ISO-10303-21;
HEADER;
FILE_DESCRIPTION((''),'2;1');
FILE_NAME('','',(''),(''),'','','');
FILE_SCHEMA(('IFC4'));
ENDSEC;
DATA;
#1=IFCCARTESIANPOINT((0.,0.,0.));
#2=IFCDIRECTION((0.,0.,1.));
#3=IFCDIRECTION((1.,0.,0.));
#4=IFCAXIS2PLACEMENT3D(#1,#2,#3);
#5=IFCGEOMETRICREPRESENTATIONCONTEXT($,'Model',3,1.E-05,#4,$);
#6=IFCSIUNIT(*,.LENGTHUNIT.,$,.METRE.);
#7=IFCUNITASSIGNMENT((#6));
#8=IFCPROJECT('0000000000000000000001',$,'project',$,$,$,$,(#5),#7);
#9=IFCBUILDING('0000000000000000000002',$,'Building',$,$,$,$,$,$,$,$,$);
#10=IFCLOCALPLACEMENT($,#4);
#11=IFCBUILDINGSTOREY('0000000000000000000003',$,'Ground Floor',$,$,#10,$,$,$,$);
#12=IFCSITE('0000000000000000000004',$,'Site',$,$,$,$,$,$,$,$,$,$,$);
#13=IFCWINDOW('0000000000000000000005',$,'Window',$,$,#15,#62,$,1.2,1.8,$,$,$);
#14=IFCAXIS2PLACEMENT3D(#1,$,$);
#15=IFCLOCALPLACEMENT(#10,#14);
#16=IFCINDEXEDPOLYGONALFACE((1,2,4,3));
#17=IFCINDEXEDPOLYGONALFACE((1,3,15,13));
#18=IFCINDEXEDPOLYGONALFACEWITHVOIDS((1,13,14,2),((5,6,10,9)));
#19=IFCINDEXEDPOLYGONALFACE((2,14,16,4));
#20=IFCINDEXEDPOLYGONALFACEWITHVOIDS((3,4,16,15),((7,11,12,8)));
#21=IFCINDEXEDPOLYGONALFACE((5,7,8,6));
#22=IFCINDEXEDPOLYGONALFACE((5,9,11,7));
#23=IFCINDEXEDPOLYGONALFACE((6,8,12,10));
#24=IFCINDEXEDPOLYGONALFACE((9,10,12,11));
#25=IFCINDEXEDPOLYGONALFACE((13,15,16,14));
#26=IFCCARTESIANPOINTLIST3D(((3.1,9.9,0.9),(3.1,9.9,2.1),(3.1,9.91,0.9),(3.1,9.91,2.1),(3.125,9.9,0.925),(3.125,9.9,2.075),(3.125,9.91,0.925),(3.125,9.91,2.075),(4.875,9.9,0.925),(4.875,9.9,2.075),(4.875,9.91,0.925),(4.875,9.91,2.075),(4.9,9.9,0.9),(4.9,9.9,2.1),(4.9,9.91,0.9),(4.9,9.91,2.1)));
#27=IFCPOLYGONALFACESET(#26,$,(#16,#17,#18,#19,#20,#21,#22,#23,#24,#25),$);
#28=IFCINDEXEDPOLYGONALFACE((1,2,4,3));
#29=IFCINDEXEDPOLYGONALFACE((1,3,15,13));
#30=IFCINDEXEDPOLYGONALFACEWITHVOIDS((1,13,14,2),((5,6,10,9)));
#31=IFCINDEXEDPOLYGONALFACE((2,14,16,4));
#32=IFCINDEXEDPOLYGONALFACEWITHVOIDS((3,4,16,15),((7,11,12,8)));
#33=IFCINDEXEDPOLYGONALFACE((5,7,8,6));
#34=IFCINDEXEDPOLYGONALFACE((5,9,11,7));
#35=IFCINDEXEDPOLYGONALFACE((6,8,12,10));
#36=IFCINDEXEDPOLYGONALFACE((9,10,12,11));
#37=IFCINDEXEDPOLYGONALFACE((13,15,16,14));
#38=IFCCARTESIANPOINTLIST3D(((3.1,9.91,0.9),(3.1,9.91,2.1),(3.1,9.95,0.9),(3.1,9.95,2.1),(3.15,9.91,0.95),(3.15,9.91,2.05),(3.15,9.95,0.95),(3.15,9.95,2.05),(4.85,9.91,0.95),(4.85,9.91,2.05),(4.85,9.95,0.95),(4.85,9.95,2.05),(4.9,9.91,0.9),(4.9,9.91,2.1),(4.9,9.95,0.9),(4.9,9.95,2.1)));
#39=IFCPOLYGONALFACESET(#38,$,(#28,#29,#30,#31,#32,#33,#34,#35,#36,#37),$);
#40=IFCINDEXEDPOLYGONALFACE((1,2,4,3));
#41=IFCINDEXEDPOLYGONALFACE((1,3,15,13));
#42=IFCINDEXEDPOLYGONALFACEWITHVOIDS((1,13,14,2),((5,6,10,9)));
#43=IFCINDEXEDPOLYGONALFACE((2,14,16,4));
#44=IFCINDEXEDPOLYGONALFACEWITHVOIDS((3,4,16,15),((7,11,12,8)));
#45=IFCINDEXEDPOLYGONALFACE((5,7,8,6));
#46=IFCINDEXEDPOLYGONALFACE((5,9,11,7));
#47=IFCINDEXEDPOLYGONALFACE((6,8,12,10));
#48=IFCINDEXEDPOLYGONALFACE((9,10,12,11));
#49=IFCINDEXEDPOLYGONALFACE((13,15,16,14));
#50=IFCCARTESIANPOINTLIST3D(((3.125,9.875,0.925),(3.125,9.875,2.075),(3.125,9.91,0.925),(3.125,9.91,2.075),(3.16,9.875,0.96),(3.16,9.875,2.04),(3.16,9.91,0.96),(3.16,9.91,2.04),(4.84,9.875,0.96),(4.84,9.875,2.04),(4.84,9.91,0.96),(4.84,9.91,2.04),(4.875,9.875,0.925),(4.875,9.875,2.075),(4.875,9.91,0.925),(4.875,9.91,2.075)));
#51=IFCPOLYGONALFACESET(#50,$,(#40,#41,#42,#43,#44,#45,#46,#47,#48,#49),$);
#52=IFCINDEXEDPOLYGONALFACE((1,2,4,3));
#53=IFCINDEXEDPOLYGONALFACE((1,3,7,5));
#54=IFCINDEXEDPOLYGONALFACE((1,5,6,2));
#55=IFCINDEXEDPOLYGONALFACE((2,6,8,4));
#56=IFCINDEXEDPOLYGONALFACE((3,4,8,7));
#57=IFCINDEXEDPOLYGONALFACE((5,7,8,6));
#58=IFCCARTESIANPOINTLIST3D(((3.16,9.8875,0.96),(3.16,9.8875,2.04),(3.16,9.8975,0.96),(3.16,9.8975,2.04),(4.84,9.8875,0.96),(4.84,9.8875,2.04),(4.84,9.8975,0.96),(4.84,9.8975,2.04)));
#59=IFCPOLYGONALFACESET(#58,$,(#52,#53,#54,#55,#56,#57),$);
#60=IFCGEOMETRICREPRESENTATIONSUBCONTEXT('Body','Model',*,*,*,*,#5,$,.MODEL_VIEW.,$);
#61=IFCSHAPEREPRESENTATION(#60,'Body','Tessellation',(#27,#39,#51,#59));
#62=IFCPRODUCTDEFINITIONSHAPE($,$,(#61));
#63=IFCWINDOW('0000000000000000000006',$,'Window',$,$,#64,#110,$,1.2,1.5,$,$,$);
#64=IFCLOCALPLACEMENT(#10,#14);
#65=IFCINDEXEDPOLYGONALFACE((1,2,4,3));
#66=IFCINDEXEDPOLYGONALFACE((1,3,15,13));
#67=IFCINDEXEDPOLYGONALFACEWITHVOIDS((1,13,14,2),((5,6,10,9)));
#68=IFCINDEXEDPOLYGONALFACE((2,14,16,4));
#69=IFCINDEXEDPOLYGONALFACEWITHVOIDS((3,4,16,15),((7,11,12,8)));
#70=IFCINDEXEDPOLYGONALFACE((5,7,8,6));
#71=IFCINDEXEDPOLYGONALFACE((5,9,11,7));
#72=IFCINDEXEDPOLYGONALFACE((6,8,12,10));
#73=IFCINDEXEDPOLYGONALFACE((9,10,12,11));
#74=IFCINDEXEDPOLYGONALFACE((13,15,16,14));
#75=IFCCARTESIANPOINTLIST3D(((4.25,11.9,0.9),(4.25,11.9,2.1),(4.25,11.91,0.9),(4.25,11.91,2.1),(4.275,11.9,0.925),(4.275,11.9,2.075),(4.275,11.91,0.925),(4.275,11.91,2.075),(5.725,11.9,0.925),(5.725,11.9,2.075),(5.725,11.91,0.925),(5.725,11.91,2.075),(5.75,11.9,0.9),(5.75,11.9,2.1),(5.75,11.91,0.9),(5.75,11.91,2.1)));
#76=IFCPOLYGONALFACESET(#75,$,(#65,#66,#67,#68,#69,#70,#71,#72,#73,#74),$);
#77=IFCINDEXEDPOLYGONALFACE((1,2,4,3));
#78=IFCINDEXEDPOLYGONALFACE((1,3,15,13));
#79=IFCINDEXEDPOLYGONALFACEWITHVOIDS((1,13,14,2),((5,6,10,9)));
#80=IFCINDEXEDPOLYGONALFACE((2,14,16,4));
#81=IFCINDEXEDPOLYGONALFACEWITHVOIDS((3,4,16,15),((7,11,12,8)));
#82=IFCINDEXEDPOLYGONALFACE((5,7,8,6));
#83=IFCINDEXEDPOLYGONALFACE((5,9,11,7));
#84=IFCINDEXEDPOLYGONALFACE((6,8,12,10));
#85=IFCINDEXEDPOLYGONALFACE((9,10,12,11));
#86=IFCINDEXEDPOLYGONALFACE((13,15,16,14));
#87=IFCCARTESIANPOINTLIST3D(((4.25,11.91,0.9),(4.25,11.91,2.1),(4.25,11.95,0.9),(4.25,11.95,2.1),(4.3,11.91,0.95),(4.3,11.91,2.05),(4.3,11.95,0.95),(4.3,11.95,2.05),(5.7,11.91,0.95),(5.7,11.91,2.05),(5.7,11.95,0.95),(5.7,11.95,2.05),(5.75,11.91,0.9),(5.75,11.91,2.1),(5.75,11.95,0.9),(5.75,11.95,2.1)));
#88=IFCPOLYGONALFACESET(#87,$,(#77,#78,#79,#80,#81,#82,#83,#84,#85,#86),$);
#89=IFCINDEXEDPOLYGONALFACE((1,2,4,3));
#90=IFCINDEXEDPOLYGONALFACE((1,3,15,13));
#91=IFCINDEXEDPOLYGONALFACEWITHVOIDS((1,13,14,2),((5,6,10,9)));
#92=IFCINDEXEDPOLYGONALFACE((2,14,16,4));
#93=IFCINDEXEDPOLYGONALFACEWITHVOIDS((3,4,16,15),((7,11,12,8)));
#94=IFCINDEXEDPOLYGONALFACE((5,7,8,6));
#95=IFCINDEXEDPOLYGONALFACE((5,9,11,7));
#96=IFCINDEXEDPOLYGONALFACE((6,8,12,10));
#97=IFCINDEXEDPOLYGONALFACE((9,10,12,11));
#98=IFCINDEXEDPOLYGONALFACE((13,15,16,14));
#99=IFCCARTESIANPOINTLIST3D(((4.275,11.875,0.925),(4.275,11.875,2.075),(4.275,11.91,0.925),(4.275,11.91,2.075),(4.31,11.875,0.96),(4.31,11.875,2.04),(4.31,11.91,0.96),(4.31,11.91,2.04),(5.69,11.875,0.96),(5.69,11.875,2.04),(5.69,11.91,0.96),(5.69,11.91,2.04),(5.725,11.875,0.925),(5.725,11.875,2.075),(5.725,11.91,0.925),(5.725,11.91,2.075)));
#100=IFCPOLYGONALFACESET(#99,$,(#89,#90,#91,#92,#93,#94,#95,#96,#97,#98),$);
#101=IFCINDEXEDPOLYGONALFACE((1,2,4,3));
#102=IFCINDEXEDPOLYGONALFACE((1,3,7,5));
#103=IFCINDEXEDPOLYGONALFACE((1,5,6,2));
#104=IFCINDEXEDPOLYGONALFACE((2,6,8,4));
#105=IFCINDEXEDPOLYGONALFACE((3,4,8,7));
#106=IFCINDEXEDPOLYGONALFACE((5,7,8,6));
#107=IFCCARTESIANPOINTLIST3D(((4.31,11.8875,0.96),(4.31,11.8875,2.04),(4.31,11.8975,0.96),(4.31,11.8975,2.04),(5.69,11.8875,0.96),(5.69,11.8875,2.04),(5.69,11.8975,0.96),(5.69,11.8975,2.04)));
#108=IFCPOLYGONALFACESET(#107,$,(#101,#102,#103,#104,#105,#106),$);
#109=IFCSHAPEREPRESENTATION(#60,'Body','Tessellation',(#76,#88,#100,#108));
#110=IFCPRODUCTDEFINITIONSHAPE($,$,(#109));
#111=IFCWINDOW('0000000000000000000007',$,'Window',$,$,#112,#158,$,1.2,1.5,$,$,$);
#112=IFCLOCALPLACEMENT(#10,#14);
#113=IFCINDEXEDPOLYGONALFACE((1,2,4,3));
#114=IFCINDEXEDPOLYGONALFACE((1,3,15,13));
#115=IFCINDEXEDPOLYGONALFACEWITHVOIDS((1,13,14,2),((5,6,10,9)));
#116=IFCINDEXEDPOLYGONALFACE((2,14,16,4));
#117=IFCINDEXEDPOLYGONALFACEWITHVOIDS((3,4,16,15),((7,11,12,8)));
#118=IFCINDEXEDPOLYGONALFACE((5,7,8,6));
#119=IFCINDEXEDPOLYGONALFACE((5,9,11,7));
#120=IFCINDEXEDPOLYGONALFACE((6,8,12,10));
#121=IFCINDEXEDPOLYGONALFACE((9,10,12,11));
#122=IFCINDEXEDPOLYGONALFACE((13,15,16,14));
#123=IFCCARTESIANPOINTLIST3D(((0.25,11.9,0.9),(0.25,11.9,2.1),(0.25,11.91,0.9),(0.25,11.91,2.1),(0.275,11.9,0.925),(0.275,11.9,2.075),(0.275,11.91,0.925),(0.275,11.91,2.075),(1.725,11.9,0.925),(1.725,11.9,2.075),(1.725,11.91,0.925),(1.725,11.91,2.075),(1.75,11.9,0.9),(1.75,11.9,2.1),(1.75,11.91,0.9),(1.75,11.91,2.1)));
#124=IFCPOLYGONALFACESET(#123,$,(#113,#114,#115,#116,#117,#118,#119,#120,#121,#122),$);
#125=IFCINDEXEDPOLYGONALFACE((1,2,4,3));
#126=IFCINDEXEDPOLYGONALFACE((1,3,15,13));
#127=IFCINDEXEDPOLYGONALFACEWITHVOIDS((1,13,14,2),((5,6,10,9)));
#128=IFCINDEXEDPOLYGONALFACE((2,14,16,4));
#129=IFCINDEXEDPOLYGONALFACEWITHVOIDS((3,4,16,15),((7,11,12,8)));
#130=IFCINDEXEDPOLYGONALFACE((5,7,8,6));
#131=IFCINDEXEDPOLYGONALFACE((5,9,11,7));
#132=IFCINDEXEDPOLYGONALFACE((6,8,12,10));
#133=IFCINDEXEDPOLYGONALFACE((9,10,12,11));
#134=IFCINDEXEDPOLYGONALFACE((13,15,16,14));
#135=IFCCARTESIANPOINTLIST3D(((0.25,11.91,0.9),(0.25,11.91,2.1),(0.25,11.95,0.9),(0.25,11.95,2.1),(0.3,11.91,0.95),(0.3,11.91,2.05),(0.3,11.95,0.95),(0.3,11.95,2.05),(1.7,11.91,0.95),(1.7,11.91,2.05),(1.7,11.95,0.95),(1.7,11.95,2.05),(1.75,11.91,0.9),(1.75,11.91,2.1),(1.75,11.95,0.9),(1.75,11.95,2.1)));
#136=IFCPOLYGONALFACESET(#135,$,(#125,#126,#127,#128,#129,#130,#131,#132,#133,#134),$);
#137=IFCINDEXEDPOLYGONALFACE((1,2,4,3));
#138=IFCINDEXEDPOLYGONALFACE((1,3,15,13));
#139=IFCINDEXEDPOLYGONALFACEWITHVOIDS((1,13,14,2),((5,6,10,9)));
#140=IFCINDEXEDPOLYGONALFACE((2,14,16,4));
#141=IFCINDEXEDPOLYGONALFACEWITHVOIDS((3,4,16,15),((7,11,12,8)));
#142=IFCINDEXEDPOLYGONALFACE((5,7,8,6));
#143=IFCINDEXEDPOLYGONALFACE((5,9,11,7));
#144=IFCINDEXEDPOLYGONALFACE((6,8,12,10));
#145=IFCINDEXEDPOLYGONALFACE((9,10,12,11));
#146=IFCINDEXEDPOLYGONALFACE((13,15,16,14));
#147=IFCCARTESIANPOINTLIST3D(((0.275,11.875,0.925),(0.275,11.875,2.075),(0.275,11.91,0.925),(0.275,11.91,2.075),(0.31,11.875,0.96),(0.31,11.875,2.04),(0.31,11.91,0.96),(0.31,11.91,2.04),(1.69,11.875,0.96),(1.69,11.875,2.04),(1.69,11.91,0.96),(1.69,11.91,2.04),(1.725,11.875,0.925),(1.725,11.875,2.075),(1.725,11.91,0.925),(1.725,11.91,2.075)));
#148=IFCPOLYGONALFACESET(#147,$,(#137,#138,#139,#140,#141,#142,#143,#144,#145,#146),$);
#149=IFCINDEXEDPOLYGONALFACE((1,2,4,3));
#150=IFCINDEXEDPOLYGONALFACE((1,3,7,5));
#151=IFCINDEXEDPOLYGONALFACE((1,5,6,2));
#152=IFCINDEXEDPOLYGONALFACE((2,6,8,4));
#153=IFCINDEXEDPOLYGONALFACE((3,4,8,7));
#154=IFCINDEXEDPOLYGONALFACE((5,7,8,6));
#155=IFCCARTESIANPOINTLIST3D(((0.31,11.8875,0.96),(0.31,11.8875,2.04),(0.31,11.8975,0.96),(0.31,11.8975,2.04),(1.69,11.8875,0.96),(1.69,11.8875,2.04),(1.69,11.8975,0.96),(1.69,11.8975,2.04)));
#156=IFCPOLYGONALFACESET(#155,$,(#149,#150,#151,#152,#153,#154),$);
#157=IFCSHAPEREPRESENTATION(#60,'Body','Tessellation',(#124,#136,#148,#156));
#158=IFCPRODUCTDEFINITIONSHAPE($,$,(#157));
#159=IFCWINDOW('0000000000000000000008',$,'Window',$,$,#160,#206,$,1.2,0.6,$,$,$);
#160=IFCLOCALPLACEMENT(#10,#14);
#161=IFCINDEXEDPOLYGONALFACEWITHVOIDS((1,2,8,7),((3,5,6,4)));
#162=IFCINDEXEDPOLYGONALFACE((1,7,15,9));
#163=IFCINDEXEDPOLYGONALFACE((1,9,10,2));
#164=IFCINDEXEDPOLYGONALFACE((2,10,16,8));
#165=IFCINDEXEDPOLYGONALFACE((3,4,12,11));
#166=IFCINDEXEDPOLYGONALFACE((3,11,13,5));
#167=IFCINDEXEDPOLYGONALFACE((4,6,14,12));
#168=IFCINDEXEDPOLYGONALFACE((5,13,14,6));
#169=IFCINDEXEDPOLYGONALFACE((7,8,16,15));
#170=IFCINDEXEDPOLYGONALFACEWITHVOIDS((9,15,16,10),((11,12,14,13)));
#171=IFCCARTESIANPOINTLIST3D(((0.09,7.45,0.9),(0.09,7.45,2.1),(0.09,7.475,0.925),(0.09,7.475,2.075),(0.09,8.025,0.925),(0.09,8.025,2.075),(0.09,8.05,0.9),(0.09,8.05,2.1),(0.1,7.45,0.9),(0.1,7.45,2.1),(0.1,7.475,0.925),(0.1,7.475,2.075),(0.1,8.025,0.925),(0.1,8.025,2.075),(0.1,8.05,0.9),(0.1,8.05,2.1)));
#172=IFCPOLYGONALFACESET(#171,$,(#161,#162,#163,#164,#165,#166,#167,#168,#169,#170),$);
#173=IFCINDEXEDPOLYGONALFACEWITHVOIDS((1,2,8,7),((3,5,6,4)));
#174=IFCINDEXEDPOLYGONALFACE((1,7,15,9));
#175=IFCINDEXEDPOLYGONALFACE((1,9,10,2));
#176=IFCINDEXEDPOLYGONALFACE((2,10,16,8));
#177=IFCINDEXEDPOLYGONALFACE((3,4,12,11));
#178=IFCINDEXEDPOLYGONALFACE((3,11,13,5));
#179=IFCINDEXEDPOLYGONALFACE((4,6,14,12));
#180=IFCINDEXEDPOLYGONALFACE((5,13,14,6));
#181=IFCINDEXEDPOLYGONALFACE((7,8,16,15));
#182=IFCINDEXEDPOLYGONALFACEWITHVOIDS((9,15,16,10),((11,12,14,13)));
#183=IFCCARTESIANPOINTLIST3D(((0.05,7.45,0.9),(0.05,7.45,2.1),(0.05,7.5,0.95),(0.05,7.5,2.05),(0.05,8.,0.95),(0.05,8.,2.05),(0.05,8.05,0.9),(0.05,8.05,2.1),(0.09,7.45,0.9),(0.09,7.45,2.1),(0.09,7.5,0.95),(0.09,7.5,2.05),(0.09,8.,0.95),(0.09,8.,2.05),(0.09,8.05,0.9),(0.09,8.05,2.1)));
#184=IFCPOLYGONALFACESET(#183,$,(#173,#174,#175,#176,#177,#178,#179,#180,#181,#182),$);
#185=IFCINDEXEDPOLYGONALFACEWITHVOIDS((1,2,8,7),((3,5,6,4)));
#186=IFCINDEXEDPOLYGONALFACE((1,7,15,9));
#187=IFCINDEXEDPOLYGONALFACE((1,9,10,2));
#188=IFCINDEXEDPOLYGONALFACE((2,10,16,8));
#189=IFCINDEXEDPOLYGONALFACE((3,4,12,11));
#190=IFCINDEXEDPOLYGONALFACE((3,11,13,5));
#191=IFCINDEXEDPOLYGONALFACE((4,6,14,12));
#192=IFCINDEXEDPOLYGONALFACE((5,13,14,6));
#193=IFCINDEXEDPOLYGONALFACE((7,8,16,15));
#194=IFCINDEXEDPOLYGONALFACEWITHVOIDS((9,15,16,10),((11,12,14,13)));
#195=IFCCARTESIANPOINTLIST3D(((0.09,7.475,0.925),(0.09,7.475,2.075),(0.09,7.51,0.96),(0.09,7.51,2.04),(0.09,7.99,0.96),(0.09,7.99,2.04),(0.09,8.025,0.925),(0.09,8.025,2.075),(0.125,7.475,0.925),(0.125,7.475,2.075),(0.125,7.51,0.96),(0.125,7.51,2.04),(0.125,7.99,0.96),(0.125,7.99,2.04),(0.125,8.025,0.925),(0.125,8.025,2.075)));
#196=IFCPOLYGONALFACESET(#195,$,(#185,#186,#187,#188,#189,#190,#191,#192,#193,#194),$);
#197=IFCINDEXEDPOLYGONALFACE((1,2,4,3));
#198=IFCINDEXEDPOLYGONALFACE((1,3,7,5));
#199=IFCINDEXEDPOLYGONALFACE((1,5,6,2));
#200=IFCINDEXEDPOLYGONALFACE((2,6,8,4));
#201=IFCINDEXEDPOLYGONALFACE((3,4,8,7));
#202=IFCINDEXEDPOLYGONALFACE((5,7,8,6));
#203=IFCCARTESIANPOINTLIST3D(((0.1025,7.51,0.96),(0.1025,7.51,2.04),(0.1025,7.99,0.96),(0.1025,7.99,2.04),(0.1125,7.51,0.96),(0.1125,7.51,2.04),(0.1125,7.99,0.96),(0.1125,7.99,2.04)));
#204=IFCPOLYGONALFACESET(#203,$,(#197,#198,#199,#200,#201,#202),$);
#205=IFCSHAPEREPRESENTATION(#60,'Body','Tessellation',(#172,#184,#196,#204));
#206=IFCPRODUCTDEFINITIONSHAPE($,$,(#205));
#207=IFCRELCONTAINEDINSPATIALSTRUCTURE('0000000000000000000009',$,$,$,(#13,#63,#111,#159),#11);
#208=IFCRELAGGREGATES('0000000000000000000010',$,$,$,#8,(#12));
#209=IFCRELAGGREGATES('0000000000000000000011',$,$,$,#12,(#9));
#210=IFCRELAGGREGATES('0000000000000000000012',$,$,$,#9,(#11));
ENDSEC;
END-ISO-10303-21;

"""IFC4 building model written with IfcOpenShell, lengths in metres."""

from ifc_helpers import new_model, si_unit, frame, origin_with_axes, place, context, subcontext, project, spatial, line, indexed_curve, outline, extrude, element, save


model = new_model("IFC4")

# Units and contexts
model_context = context("Model", 3, precision=1e-05, world=origin_with_axes())
body_context = subcontext(model_context, "Body", "Model", "MODEL_VIEW")
ifc_project = project(units=[si_unit("LENGTHUNIT", "METRE")], contexts=[model_context])

# Site, building, storey
site = spatial("IfcSite", under=ifc_project, Name="Site")
building = spatial("IfcBuilding", under=site, Name="Building")
storey_placement = place(None, origin_with_axes())
storey = spatial("IfcBuildingStorey", under=building, at=storey_placement, Name="Ground Floor")

# Windows
window_1_placement = place(storey_placement, frame((4.9, 10.0, 0.9), z_axis=(0.0, 0.0, 1.0), x_axis=(-1.0, 0.0, 0.0)))
element("IfcWindow", 1, at=window_1_placement, inside=storey, Name="Window", OverallHeight=1.2, OverallWidth=1.8, context=body_context, shape_type="SweptSolid", body=[
    extrude(outline(indexed_curve([(0.0, 0.0), (1.8, 0.0), (1.8, 1.2), (0.0, 1.2)], segments=[line(1, 2, 3, 4, 1)]), holes=[indexed_curve([(0.025, 0.025), (1.775, 0.025), (1.775, 1.175), (0.025, 1.175)], segments=[line(1, 2, 3, 4, 1)])]), frame((0.0, 0.09, 0.0), z_axis=(0.0, -1.0, 0.0), x_axis=(1.0, 0.0, 0.0)), (0.0, 0.0, -1.0), 0.01),
    extrude(outline(indexed_curve([(0.0, 0.0), (1.8, 0.0), (1.8, 1.2), (0.0, 1.2)], segments=[line(1, 2, 3, 4, 1)]), holes=[indexed_curve([(0.05, 0.05), (1.75, 0.05), (1.75, 1.15), (0.05, 1.15)], segments=[line(1, 2, 3, 4, 1)])]), frame((0.0, 0.05, 0.0), z_axis=(0.0, -1.0, 0.0), x_axis=(1.0, 0.0, 0.0)), (0.0, 0.0, -1.0), 0.04),
    extrude(outline(indexed_curve([(0.0, 0.0), (1.75, 0.0), (1.75, 1.15), (0.0, 1.15)], segments=[line(1, 2, 3, 4, 1)]), holes=[indexed_curve([(0.035, 0.035), (1.715, 0.035), (1.715, 1.115), (0.035, 1.115)], segments=[line(1, 2, 3, 4, 1)])]), frame((0.025, 0.09, 0.025), z_axis=(0.0, -1.0, 0.0), x_axis=(1.0, 0.0, 0.0)), (0.0, 0.0, -1.0), 0.035),
    extrude(outline(indexed_curve([(0.035, 0.035), (1.715, 0.035), (1.715, 1.115), (0.035, 1.115)], segments=[line(1, 2, 3, 4, 1)])), frame((0.025, 0.1025, 0.025), z_axis=(0.0, -1.0, 0.0), x_axis=(1.0, 0.0, 0.0)), (0.0, 0.0, -1.0), 0.01),
])
for number, where, z_axis, x_axis, name in (
    (2, (5.75, 12.0, 0.9), (0.0, 0.0, 1.0), (-1.0, 0.0, 0.0), "Window"),
    (3, (1.75, 12.0, 0.9), (0.0, 0.0, 1.0), (-1.0, 0.0, 0.0), "Window"),
):
    element("IfcWindow", number, at=place(storey_placement, frame(where, z_axis=z_axis, x_axis=x_axis)), inside=storey, Name=name, OverallHeight=1.2, OverallWidth=1.5, context=body_context, shape_type="SweptSolid", body=[
        extrude(outline(indexed_curve([(0.0, 0.0), (1.5, 0.0), (1.5, 1.2), (0.0, 1.2)], segments=[line(1, 2, 3, 4, 1)]), holes=[indexed_curve([(0.025, 0.025), (1.475, 0.025), (1.475, 1.175), (0.025, 1.175)], segments=[line(1, 2, 3, 4, 1)])]), frame((0.0, 0.09, 0.0), z_axis=(0.0, -1.0, 0.0), x_axis=(1.0, 0.0, 0.0)), (0.0, 0.0, -1.0), 0.01),
        extrude(outline(indexed_curve([(0.0, 0.0), (1.5, 0.0), (1.5, 1.2), (0.0, 1.2)], segments=[line(1, 2, 3, 4, 1)]), holes=[indexed_curve([(0.05, 0.05), (1.45, 0.05), (1.45, 1.15), (0.05, 1.15)], segments=[line(1, 2, 3, 4, 1)])]), frame((0.0, 0.05, 0.0), z_axis=(0.0, -1.0, 0.0), x_axis=(1.0, 0.0, 0.0)), (0.0, 0.0, -1.0), 0.04),
        extrude(outline(indexed_curve([(0.0, 0.0), (1.45, 0.0), (1.45, 1.15), (0.0, 1.15)], segments=[line(1, 2, 3, 4, 1)]), holes=[indexed_curve([(0.035, 0.035), (1.415, 0.035), (1.415, 1.115), (0.035, 1.115)], segments=[line(1, 2, 3, 4, 1)])]), frame((0.025, 0.09, 0.025), z_axis=(0.0, -1.0, 0.0), x_axis=(1.0, 0.0, 0.0)), (0.0, 0.0, -1.0), 0.035),
        extrude(outline(indexed_curve([(0.035, 0.035), (1.415, 0.035), (1.415, 1.115), (0.035, 1.115)], segments=[line(1, 2, 3, 4, 1)])), frame((0.025, 0.1025, 0.025), z_axis=(0.0, -1.0, 0.0), x_axis=(1.0, 0.0, 0.0)), (0.0, 0.0, -1.0), 0.01),
    ])
window_2_placement = place(storey_placement, frame((0.0, 8.05, 0.9), z_axis=(0.0, 0.0, 1.0), x_axis=(0.0, -1.0, 0.0)))
element("IfcWindow", 4, at=window_2_placement, inside=storey, Name="Window", OverallHeight=1.2, OverallWidth=0.6, context=body_context, shape_type="SweptSolid", body=[
    extrude(outline(indexed_curve([(0.0, 0.0), (0.6, 0.0), (0.6, 1.2), (0.0, 1.2)], segments=[line(1, 2, 3, 4, 1)]), holes=[indexed_curve([(0.025, 0.025), (0.575, 0.025), (0.575, 1.175), (0.025, 1.175)], segments=[line(1, 2, 3, 4, 1)])]), frame((0.0, 0.09, 0.0), z_axis=(0.0, -1.0, 0.0), x_axis=(1.0, 0.0, 0.0)), (0.0, 0.0, -1.0), 0.01),
    extrude(outline(indexed_curve([(0.0, 0.0), (0.6, 0.0), (0.6, 1.2), (0.0, 1.2)], segments=[line(1, 2, 3, 4, 1)]), holes=[indexed_curve([(0.05, 0.05), (0.55, 0.05), (0.55, 1.15), (0.05, 1.15)], segments=[line(1, 2, 3, 4, 1)])]), frame((0.0, 0.05, 0.0), z_axis=(0.0, -1.0, 0.0), x_axis=(1.0, 0.0, 0.0)), (0.0, 0.0, -1.0), 0.04),
    extrude(outline(indexed_curve([(0.0, 0.0), (0.55, 0.0), (0.55, 1.15), (0.0, 1.15)], segments=[line(1, 2, 3, 4, 1)]), holes=[indexed_curve([(0.035, 0.035), (0.515, 0.035), (0.515, 1.115), (0.035, 1.115)], segments=[line(1, 2, 3, 4, 1)])]), frame((0.025, 0.09, 0.025), z_axis=(0.0, -1.0, 0.0), x_axis=(1.0, 0.0, 0.0)), (0.0, 0.0, -1.0), 0.035),
    extrude(outline(indexed_curve([(0.035, 0.035), (0.515, 0.035), (0.515, 1.115), (0.035, 1.115)], segments=[line(1, 2, 3, 4, 1)])), frame((0.025, 0.1025, 0.025), z_axis=(0.0, -1.0, 0.0), x_axis=(1.0, 0.0, 0.0)), (0.0, 0.0, -1.0), 0.01),
])

save(model, "model.ifc")
